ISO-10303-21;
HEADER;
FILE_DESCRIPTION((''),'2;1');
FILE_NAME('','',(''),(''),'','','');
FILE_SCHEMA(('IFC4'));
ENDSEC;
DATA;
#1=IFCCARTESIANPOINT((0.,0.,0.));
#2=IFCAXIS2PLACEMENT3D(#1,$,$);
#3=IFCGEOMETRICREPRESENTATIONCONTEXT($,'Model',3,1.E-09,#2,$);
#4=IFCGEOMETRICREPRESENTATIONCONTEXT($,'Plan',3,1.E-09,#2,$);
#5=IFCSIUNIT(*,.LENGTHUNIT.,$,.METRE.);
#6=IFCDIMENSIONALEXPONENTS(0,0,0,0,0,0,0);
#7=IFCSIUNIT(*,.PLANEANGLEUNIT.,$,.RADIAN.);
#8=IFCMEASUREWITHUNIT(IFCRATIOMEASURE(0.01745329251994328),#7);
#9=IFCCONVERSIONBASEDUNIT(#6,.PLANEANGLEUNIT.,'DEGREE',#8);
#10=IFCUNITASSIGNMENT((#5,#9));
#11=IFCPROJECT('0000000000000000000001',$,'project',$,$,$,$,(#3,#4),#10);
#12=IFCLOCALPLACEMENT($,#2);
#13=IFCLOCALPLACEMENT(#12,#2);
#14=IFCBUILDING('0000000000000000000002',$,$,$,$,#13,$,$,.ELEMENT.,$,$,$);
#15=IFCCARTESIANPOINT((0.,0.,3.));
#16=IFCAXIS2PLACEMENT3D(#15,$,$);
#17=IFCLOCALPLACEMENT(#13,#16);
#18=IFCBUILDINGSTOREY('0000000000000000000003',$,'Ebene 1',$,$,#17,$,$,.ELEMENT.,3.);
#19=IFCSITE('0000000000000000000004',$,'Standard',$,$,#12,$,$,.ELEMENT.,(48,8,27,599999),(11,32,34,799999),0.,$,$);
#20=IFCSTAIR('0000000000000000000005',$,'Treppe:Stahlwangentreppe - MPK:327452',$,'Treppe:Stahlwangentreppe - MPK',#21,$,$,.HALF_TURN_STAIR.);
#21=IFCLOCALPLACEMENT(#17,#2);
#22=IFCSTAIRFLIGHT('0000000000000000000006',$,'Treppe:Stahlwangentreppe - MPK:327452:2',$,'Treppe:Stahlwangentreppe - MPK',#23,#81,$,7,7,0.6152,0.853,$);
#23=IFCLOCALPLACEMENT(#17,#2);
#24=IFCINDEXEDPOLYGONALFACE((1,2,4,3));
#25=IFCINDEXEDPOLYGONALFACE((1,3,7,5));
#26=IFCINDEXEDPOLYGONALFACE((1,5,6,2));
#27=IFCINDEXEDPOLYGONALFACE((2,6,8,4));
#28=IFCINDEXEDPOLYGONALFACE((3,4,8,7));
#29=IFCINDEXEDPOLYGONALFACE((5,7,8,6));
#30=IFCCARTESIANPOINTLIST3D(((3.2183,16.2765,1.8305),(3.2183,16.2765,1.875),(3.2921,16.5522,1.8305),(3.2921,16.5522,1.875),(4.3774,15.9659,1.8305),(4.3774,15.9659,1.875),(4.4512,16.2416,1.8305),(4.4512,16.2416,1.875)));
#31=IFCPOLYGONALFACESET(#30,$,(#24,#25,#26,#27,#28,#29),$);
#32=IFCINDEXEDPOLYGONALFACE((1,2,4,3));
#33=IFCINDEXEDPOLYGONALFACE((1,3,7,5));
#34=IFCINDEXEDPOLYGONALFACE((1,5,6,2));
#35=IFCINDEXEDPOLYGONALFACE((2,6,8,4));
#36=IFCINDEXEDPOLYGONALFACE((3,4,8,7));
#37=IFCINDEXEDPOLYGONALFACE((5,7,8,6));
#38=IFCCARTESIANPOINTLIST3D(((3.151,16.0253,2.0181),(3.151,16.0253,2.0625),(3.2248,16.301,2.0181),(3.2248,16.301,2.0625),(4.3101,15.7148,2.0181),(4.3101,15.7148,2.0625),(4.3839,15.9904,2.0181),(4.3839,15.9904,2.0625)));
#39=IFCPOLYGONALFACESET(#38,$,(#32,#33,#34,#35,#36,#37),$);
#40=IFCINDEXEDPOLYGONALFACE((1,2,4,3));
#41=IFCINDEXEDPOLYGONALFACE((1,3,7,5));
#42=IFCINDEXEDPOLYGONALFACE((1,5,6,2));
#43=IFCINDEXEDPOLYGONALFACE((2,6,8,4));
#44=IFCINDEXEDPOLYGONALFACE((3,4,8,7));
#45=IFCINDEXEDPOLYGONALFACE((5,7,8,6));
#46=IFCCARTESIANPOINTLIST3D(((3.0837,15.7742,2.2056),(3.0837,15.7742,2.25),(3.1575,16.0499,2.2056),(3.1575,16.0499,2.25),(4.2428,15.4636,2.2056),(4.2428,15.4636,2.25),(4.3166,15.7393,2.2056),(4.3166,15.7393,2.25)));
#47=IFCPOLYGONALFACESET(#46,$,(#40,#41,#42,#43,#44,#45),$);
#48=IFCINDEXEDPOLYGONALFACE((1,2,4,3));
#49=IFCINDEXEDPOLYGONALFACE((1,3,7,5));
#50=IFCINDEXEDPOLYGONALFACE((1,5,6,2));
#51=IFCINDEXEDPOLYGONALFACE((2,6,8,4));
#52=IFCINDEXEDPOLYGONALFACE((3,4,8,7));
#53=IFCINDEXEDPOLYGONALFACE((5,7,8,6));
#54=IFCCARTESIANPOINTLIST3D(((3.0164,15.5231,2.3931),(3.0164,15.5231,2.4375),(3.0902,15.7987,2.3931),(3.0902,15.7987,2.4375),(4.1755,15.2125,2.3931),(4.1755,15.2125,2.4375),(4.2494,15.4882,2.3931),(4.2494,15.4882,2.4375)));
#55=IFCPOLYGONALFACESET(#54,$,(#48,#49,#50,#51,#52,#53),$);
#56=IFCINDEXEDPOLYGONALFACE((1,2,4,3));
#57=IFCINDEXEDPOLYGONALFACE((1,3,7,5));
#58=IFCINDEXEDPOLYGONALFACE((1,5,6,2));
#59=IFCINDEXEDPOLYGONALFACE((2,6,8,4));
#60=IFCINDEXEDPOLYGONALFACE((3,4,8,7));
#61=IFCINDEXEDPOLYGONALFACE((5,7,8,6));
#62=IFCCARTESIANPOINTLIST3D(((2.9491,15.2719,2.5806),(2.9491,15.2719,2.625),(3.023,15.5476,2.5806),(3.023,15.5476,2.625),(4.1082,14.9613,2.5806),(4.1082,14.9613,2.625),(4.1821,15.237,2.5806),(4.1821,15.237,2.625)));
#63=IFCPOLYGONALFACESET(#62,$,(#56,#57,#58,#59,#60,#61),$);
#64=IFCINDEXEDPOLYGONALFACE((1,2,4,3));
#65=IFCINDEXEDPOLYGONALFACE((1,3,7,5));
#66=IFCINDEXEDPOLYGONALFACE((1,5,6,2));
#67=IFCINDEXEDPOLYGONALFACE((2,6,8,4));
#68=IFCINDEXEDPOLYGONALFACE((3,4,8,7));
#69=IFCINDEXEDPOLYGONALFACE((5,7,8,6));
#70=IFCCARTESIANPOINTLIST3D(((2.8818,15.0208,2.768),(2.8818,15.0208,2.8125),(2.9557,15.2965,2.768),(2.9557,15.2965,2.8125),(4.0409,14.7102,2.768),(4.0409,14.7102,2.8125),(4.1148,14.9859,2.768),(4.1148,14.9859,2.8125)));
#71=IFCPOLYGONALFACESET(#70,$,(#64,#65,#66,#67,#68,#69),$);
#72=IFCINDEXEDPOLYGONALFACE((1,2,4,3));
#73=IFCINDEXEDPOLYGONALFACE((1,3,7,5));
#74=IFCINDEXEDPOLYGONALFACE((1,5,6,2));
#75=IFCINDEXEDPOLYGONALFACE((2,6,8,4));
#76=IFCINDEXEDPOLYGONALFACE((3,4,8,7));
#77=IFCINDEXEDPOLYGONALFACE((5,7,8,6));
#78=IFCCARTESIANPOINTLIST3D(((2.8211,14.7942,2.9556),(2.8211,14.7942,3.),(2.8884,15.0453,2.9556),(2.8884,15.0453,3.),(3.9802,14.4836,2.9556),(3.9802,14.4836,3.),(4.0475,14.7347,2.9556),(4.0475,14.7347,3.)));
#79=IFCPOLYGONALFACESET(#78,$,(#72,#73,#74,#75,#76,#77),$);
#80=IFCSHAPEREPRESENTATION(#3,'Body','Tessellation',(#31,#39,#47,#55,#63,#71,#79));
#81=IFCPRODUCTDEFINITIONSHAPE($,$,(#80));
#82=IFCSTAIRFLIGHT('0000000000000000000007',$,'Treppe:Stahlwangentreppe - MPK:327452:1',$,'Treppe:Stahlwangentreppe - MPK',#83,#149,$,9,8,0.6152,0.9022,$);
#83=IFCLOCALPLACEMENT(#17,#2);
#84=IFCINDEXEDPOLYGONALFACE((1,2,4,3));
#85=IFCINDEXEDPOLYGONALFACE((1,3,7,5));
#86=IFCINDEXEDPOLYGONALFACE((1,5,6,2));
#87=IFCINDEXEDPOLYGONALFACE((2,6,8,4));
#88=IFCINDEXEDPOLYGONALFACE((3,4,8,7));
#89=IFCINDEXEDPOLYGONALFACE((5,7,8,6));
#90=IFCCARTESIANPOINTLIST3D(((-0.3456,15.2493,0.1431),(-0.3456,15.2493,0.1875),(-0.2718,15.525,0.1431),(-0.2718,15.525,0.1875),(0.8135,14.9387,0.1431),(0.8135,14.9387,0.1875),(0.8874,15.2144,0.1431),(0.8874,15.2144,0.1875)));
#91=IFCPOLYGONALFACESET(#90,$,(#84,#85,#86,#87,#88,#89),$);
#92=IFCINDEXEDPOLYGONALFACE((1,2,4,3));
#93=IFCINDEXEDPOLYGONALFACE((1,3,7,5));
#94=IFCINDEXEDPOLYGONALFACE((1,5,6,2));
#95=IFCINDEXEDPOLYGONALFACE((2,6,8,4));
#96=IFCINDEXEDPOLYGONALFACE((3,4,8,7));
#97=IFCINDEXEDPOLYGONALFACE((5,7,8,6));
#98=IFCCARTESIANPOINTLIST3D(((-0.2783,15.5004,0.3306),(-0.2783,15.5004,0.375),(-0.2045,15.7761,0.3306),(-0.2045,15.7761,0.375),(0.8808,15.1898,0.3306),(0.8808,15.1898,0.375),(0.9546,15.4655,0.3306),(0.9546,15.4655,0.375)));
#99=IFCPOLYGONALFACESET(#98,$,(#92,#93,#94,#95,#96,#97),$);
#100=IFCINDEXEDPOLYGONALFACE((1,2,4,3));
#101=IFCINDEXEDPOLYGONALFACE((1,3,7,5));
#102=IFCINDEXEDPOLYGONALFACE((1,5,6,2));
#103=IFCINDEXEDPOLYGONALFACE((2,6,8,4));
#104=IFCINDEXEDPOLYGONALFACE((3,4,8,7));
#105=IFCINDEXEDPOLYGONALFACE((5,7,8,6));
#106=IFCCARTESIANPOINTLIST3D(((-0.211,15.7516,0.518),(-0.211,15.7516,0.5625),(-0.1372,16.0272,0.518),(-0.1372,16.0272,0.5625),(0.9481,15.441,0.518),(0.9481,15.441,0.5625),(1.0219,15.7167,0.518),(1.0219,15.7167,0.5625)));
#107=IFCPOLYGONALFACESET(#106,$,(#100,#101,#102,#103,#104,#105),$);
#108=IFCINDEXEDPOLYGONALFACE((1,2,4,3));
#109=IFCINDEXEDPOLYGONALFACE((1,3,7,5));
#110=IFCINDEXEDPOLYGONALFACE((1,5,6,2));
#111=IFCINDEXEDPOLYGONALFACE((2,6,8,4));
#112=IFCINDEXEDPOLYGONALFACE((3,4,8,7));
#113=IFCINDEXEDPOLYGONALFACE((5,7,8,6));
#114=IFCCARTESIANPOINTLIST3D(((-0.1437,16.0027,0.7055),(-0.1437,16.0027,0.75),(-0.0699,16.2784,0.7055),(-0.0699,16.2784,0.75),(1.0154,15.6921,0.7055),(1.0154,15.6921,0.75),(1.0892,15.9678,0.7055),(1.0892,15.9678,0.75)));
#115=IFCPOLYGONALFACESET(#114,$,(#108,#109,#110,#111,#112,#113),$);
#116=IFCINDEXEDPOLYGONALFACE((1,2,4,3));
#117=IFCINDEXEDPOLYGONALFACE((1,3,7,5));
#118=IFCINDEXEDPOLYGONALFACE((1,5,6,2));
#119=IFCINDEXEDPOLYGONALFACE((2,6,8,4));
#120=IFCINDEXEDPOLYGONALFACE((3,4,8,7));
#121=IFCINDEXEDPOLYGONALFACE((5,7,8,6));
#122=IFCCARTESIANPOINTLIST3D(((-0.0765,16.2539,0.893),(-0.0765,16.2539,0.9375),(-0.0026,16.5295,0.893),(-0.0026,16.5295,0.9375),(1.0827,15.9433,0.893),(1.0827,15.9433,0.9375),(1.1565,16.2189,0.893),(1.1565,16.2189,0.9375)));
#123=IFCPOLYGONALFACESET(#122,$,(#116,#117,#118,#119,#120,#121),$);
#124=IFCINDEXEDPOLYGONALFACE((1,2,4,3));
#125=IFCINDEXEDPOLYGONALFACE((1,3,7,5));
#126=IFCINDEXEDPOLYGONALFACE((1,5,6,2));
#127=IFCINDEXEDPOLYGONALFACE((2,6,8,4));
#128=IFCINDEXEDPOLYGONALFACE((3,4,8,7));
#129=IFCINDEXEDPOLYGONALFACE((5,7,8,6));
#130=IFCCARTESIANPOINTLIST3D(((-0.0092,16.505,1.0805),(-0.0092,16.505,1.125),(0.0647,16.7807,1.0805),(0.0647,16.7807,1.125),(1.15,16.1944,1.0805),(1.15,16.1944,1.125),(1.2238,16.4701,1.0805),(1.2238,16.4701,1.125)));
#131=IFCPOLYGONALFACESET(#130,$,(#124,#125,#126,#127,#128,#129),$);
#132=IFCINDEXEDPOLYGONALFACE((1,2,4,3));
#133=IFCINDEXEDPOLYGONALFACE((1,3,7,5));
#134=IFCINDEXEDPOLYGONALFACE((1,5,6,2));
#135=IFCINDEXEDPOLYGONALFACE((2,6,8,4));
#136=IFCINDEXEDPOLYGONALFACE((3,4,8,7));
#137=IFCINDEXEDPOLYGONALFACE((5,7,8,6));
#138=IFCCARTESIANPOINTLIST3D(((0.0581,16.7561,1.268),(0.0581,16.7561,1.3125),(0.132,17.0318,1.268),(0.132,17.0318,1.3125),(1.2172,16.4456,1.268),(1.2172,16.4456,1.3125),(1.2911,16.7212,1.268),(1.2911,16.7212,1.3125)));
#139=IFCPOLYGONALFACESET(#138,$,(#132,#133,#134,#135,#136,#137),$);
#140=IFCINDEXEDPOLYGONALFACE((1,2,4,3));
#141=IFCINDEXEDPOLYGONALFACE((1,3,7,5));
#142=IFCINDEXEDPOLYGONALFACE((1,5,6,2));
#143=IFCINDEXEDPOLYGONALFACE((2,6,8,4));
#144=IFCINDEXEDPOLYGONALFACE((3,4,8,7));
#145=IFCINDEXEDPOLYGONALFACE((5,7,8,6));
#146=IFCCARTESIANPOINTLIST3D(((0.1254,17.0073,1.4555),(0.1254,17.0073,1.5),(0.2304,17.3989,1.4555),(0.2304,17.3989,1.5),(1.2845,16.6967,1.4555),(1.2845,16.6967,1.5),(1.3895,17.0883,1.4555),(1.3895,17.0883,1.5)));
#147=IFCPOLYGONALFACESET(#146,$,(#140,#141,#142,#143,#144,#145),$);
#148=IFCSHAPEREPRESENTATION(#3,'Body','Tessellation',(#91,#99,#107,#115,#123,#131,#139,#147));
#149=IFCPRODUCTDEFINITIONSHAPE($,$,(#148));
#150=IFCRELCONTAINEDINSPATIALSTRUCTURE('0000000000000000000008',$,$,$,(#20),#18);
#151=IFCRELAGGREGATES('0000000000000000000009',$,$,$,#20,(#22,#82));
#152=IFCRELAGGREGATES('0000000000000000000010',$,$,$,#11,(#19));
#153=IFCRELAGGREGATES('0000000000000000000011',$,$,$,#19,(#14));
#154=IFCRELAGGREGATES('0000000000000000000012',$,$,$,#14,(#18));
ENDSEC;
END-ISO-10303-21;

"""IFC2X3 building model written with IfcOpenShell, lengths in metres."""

from ifc_helpers import new_model, entity, si_unit, converted_unit, frame, frame_2d, origin, origin_2d_with_axis, place, context, project, spatial, rectangle, extrude, element, aggregate, save


model = new_model("IFC2X3")

# Units and contexts
model_context = context("Model", 3, precision=1e-09, world=origin())
plan_context = context("Plan", 3, precision=1e-09, world=origin())
ifc_project = project(units=[si_unit("LENGTHUNIT", "METRE"), converted_unit("PLANEANGLEUNIT", "DEGREE", entity("IfcRatioMeasure", 0.01745329251994328), si_unit("PLANEANGLEUNIT", "RADIAN"), dimensions=[0, 0, 0, 0, 0, 0, 0])], contexts=[model_context, plan_context])

# Site, building, storey
site_placement = place(None, origin())
site = spatial("IfcSite", under=ifc_project, at=site_placement, Name="Standard", CompositionType="ELEMENT", RefLatitude=(48, 8, 27, 599999), RefLongitude=(11, 32, 34, 799999), RefElevation=0.0)
building_placement = place(site_placement, origin())
building = spatial("IfcBuilding", under=site, at=building_placement, CompositionType="ELEMENT")
storey_placement = place(building_placement, frame((0.0, 0.0, 3.0)))
storey = spatial("IfcBuildingStorey", under=building, at=storey_placement, Name="Ebene 1", CompositionType="ELEMENT", Elevation=3.0)

# Stair
stair_placement = place(storey_placement, origin())
stair = element("IfcStair", 1, at=stair_placement, inside=storey, Name="Treppe:Stahlwangentreppe - MPK:327452", ObjectType="Treppe:Stahlwangentreppe - MPK", ShapeType="HALF_TURN_STAIR")

# Stair flights
stair_flight_1_placement = place(storey_placement, origin())
stair_flight_1 = element("IfcStairFlight", 2, at=stair_flight_1_placement, Name="Treppe:Stahlwangentreppe - MPK:327452:2", ObjectType="Treppe:Stahlwangentreppe - MPK", NumberOfRiser=7, NumberOfTreads=7, RiserHeight=0.6152, TreadLength=0.853, context=model_context, shape_type="SweptSolid", body=[
    extrude(rectangle(XDim=0.2854, YDim=1.2, at=origin_2d_with_axis()), frame((3.8347, 16.259, 1.8305), z_axis=(0.0, 0.0, 1.0), x_axis=(0.258819, 0.965926, 0.0)), (0.0, 0.0, 1.0), 0.0444),
    extrude(rectangle(XDim=0.2854, YDim=1.2, at=origin_2d_with_axis()), frame((3.7675, 16.0079, 2.0181), z_axis=(0.0, 0.0, 1.0), x_axis=(0.258819, 0.965926, 0.0)), (0.0, 0.0, 1.0), 0.0444),
    extrude(rectangle(XDim=0.2854, YDim=1.2, at=origin_2d_with_axis()), frame((3.7002, 15.7568, 2.2056), z_axis=(0.0, 0.0, 1.0), x_axis=(0.258819, 0.965926, 0.0)), (0.0, 0.0, 1.0), 0.0444),
    extrude(rectangle(XDim=0.2854, YDim=1.2, at=origin_2d_with_axis()), frame((3.6329, 15.5056, 2.3931), z_axis=(0.0, 0.0, 1.0), x_axis=(0.258819, 0.965926, 0.0)), (0.0, 0.0, 1.0), 0.0444),
    extrude(rectangle(XDim=0.2854, YDim=1.2, at=origin_2d_with_axis()), frame((3.5656, 15.2545, 2.5806), z_axis=(0.0, 0.0, 1.0), x_axis=(0.258819, 0.965926, 0.0)), (0.0, 0.0, 1.0), 0.0445),
    extrude(rectangle(XDim=0.2854, YDim=1.2, at=origin_2d_with_axis()), frame((3.4983, 15.0033, 2.768), z_axis=(0.0, 0.0, 1.0), x_axis=(0.258819, 0.965926, 0.0)), (0.0, 0.0, 1.0), 0.0445),
    extrude(rectangle(XDim=0.26, YDim=1.2, at=origin_2d_with_axis()), frame((3.4343, 14.7645, 2.9556), z_axis=(0.0, 0.0, 1.0), x_axis=(0.258819, 0.965926, 0.0)), (0.0, 0.0, 1.0), 0.0445),
])
stair_flight_2_placement = place(storey_placement, origin())
stair_flight_2 = element("IfcStairFlight", 3, at=stair_flight_2_placement, Name="Treppe:Stahlwangentreppe - MPK:327452:1", ObjectType="Treppe:Stahlwangentreppe - MPK", NumberOfRiser=9, NumberOfTreads=8, RiserHeight=0.6152, TreadLength=0.9022, context=model_context, shape_type="SweptSolid", body=[
    extrude(rectangle(XDim=0.2854, YDim=1.2, at=origin_2d_with_axis()), frame((0.2709, 15.2318, 0.1431), z_axis=(0.0, 0.0, 1.0), x_axis=(-0.258819, -0.965926, 0.0)), (0.0, 0.0, 1.0), 0.0445),
    extrude(rectangle(XDim=0.2854, YDim=1.2, at=origin_2d_with_axis()), frame((0.3382, 15.483, 0.3306), z_axis=(0.0, 0.0, 1.0), x_axis=(-0.258819, -0.965926, 0.0)), (0.0, 0.0, 1.0), 0.0445),
    extrude(rectangle(XDim=0.2854, YDim=1.2, at=origin_2d_with_axis()), frame((0.4055, 15.7341, 0.518), z_axis=(0.0, 0.0, 1.0), x_axis=(-0.258819, -0.965926, 0.0)), (0.0, 0.0, 1.0), 0.0445),
    extrude(rectangle(XDim=0.2854, YDim=1.2, at=origin_2d_with_axis()), frame((0.4727, 15.9853, 0.7055), z_axis=(0.0, 0.0, 1.0), x_axis=(-0.258819, -0.965926, 0.0)), (0.0, 0.0, 1.0), 0.0445),
    extrude(rectangle(XDim=0.2854, YDim=1.2, at=origin_2d_with_axis()), frame((0.54, 16.2364, 0.893), z_axis=(0.0, 0.0, 1.0), x_axis=(-0.258819, -0.965926, 0.0)), (0.0, 0.0, 1.0), 0.0445),
    extrude(rectangle(XDim=0.2854, YDim=1.2, at=origin_2d_with_axis()), frame((0.6073, 16.4875, 1.0805), z_axis=(0.0, 0.0, 1.0), x_axis=(-0.258819, -0.965926, 0.0)), (0.0, 0.0, 1.0), 0.0445),
    extrude(rectangle(XDim=0.2854, YDim=1.2, at=origin_2d_with_axis()), frame((0.6746, 16.7387, 1.268), z_axis=(0.0, 0.0, 1.0), x_axis=(-0.258819, -0.965926, 0.0)), (0.0, 0.0, 1.0), 0.0444),
    extrude(rectangle(XDim=0.4054, YDim=1.2, at=frame_2d((0.0355, 0.12), x_axis=(1.0, 0.0))), frame((0.6507, 17.1131, 1.4555), z_axis=(0.0, 0.0, 1.0), x_axis=(-0.258819, -0.965926, 0.0)), (0.0, 0.0, 1.0), 0.0444),
])
aggregate(stair, [stair_flight_1, stair_flight_2])

save(model, "model.ifc")
